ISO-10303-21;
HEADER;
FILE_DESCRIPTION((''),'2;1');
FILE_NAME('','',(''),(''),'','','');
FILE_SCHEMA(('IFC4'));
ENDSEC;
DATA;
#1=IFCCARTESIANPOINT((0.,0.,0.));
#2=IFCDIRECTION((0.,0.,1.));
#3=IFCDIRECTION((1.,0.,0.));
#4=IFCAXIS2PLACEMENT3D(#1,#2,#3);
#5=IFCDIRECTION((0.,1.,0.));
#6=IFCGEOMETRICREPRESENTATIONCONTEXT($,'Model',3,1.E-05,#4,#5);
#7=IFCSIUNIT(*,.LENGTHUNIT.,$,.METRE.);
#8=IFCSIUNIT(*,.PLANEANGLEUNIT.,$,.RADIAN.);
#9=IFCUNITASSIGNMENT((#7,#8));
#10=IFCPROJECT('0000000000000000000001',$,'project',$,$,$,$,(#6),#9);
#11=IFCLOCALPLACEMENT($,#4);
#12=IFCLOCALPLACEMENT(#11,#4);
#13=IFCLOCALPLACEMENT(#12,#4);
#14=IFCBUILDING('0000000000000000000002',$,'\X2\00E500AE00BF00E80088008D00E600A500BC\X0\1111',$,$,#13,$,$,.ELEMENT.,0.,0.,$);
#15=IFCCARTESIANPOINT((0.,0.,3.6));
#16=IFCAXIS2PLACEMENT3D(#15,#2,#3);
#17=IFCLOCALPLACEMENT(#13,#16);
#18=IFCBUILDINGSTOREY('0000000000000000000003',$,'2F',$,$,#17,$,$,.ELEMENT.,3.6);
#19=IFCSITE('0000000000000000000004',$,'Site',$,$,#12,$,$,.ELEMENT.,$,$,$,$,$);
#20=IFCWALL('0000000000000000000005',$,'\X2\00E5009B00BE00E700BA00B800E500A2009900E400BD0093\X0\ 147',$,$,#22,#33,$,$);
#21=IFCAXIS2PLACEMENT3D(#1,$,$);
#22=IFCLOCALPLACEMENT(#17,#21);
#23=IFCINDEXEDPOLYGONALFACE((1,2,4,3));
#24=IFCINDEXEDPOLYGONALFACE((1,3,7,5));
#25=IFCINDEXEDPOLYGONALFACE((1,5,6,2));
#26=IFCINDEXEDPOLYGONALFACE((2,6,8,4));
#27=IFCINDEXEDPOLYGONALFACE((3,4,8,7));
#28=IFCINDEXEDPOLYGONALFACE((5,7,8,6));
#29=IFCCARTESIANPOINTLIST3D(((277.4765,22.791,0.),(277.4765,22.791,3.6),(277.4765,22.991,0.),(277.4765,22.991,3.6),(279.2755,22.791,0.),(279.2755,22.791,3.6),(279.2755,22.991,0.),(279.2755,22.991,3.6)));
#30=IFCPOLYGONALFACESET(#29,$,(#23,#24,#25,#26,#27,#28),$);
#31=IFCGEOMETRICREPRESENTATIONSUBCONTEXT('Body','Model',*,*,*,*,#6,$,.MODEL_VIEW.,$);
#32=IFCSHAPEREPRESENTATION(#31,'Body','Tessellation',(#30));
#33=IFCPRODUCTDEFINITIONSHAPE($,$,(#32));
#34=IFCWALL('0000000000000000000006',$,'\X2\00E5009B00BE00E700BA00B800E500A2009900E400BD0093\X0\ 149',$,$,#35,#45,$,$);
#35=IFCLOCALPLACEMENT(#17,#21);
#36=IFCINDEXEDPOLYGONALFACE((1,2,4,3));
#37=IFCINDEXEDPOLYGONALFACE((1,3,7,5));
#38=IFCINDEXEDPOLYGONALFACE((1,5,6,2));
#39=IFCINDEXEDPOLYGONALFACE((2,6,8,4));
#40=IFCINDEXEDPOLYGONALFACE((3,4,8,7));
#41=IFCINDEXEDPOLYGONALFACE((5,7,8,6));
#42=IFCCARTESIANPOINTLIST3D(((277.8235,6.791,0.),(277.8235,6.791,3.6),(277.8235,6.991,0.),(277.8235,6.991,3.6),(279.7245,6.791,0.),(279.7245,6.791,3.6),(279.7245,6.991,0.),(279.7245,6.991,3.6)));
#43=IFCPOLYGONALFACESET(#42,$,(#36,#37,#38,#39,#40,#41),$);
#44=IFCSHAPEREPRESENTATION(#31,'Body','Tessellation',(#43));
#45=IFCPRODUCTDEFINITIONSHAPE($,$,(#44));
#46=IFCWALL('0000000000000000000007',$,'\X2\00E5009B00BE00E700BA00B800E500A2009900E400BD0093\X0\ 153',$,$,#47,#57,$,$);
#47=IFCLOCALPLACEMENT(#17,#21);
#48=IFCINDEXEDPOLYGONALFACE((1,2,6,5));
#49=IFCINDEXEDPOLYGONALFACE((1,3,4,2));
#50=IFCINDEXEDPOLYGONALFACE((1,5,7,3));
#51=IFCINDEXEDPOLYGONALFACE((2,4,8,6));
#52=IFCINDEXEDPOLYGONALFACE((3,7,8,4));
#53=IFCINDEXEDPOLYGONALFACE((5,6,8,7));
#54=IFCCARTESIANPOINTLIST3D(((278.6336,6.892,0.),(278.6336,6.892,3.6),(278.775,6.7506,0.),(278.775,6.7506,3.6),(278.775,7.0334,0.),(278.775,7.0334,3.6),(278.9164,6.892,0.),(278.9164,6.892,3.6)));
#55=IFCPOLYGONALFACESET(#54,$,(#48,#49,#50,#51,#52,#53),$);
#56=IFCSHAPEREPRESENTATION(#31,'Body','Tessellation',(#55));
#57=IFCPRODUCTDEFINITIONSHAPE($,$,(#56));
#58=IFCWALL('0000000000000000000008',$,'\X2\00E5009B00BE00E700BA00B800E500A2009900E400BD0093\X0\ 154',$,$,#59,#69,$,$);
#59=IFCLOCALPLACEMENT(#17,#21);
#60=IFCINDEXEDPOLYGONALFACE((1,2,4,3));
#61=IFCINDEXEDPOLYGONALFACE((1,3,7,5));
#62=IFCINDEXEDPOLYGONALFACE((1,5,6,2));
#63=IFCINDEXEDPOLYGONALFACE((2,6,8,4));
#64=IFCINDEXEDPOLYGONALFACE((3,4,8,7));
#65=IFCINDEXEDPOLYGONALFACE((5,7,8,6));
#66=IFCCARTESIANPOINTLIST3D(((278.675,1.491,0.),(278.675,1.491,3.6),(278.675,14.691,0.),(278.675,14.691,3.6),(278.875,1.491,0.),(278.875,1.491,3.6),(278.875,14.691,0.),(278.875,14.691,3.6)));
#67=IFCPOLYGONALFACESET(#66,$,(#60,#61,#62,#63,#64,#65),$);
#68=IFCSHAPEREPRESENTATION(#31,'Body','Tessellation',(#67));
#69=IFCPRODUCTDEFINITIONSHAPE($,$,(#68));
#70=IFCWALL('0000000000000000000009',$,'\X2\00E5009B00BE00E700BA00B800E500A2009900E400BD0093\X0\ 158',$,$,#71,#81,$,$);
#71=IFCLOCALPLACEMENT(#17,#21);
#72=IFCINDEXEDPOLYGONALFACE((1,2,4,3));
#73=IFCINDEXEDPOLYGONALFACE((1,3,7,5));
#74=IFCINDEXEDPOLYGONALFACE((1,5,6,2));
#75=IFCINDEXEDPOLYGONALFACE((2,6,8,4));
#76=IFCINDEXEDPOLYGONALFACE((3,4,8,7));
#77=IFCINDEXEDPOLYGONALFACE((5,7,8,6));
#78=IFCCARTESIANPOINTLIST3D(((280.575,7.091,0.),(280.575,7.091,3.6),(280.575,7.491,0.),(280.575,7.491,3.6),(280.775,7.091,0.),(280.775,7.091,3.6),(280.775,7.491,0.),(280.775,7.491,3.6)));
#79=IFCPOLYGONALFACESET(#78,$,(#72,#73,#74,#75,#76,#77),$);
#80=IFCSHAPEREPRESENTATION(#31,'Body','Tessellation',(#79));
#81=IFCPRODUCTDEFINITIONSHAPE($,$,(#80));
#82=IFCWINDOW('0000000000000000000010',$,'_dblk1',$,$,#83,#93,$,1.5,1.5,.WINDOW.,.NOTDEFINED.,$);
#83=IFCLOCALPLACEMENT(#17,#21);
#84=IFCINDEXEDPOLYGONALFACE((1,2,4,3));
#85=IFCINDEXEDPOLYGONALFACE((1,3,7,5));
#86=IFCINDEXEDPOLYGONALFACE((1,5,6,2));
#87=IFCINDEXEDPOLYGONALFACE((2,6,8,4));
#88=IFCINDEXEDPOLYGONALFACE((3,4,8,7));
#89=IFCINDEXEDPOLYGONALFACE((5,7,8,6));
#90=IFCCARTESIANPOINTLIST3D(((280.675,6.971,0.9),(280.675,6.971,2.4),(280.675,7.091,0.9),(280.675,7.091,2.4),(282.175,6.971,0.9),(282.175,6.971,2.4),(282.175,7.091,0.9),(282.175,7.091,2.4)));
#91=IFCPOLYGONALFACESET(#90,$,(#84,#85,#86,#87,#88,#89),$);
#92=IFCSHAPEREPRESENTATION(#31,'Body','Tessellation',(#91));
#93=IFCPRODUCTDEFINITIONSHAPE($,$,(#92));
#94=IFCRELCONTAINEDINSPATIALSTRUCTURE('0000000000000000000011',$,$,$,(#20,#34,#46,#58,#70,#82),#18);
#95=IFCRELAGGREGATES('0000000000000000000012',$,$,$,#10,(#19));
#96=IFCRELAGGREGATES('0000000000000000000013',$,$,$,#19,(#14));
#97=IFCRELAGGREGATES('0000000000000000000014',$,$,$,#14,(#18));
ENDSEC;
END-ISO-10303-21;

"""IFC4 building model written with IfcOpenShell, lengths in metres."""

from ifc_helpers import new_model, si_unit, direction, frame, frame_2d, origin_with_axes, place, context, subcontext, project, spatial, rectangle, extrude, element, save


model = new_model("IFC4")

# Units and contexts
model_context = context("Model", 3, precision=1e-05, world=origin_with_axes(), true_north=direction((0.0, 1.0, 0.0)))
body_context = subcontext(model_context, "Body", "Model", "MODEL_VIEW")
ifc_project = project(units=[si_unit("LENGTHUNIT", "METRE"), si_unit("PLANEANGLEUNIT", "RADIAN")], contexts=[model_context])

# Site, building, storey
placement = place(None, origin_with_axes())
site_placement = place(placement, origin_with_axes())
site = spatial("IfcSite", under=ifc_project, at=site_placement, Name="Site", CompositionType="ELEMENT")
building_placement = place(site_placement, origin_with_axes())
building = spatial("IfcBuilding", under=site, at=building_placement, Name="å®¿è\u0088\u008dæ¥¼1111", CompositionType="ELEMENT", ElevationOfRefHeight=0.0, ElevationOfTerrain=0.0)
storey_placement = place(building_placement, frame((0.0, 0.0, 3.6), z_axis=(0.0, 0.0, 1.0), x_axis=(1.0, 0.0, 0.0)))
storey = spatial("IfcBuildingStorey", under=building, at=storey_placement, Name="2F", CompositionType="ELEMENT", Elevation=3.6)

# Walls
wall_1_placement = place(storey_placement, frame((278.376, 22.891, 0.0), z_axis=(0.0, 0.0, 1.0), x_axis=(1.0, 0.0, 0.0)))
element("IfcWall", 1, at=wall_1_placement, inside=storey, Name="å\u009b¾çº¸å¢\u0099ä½\u0093 147", context=body_context, shape_type="SweptSolid", body=[
    extrude(rectangle(XDim=1.799, YDim=0.2, at=frame_2d((0.0, 0.0), x_axis=(1.0, 0.0, 0.0))), frame((0.0, 0.0, 0.0), z_axis=(0.0, 0.0, 1.0)), (0.0, 0.0, 1.0), 3.6),
])
wall_2_placement = place(storey_placement, frame((278.774, 6.891, 0.0), z_axis=(0.0, 0.0, 1.0), x_axis=(1.0, 0.0, 0.0)))
element("IfcWall", 2, at=wall_2_placement, inside=storey, Name="å\u009b¾çº¸å¢\u0099ä½\u0093 149", context=body_context, shape_type="SweptSolid", body=[
    extrude(rectangle(XDim=1.901, YDim=0.2, at=frame_2d((0.0, 0.0), x_axis=(1.0, 0.0, 0.0))), frame((0.0, 0.0, 0.0), z_axis=(0.0, 0.0, 1.0)), (0.0, 0.0, 1.0), 3.6),
])
wall_3_placement = place(storey_placement, frame((278.775, 6.892, 0.0), z_axis=(0.0, 0.0, 1.0), x_axis=(-0.707107, -0.707107, 0.0)))
element("IfcWall", 3, at=wall_3_placement, inside=storey, Name="å\u009b¾çº¸å¢\u0099ä½\u0093 153", context=body_context, shape_type="SweptSolid", body=[
    extrude(rectangle(XDim=0.2, YDim=0.2, at=frame_2d((0.0, 0.0), x_axis=(1.0, 0.0, 0.0))), frame((0.0, 0.0, 0.0), z_axis=(0.0, 0.0, 1.0)), (0.0, 0.0, 1.0), 3.6),
])
wall_4_placement = place(storey_placement, frame((278.775, 8.091, 0.0), z_axis=(0.0, 0.0, 1.0), x_axis=(0.0, 1.0, 0.0)))
element("IfcWall", 4, at=wall_4_placement, inside=storey, Name="å\u009b¾çº¸å¢\u0099ä½\u0093 154", context=body_context, shape_type="SweptSolid", body=[
    extrude(rectangle(XDim=13.2, YDim=0.2, at=frame_2d((0.0, 0.0), x_axis=(1.0, 0.0, 0.0))), frame((0.0, 0.0, 0.0), z_axis=(0.0, 0.0, 1.0)), (0.0, 0.0, 1.0), 3.6),
])
wall_5_placement = place(storey_placement, frame((280.675, 7.291, 0.0), z_axis=(0.0, 0.0, 1.0), x_axis=(0.0, -1.0, 0.0)))
element("IfcWall", 5, at=wall_5_placement, inside=storey, Name="å\u009b¾çº¸å¢\u0099ä½\u0093 158", context=body_context, shape_type="SweptSolid", body=[
    extrude(rectangle(XDim=0.4, YDim=0.2, at=frame_2d((0.0, 0.0), x_axis=(1.0, 0.0, 0.0))), frame((0.0, 0.0, 0.0), z_axis=(0.0, 0.0, 1.0)), (0.0, 0.0, 1.0), 3.6),
])

# Window
window_placement = place(storey_placement, frame((281.425, 7.031, 0.9), z_axis=(0.0, 0.0, 1.0), x_axis=(1.0, 0.0, 0.0)))
element("IfcWindow", 6, at=window_placement, inside=storey, Name="_dblk1", OverallHeight=1.5, OverallWidth=1.5, PartitioningType="NOTDEFINED", PredefinedType="WINDOW", context=body_context, shape_type="SweptSolid", body=[
    extrude(rectangle(XDim=1.5, YDim=0.12, at=frame_2d((0.0, 0.0), x_axis=(1.0, 0.0, 0.0))), frame((0.0, 0.0, 0.0), z_axis=(0.0, 0.0, 1.0)), (0.0, 0.0, 1.0), 1.5),
])

save(model, "model.ifc")
